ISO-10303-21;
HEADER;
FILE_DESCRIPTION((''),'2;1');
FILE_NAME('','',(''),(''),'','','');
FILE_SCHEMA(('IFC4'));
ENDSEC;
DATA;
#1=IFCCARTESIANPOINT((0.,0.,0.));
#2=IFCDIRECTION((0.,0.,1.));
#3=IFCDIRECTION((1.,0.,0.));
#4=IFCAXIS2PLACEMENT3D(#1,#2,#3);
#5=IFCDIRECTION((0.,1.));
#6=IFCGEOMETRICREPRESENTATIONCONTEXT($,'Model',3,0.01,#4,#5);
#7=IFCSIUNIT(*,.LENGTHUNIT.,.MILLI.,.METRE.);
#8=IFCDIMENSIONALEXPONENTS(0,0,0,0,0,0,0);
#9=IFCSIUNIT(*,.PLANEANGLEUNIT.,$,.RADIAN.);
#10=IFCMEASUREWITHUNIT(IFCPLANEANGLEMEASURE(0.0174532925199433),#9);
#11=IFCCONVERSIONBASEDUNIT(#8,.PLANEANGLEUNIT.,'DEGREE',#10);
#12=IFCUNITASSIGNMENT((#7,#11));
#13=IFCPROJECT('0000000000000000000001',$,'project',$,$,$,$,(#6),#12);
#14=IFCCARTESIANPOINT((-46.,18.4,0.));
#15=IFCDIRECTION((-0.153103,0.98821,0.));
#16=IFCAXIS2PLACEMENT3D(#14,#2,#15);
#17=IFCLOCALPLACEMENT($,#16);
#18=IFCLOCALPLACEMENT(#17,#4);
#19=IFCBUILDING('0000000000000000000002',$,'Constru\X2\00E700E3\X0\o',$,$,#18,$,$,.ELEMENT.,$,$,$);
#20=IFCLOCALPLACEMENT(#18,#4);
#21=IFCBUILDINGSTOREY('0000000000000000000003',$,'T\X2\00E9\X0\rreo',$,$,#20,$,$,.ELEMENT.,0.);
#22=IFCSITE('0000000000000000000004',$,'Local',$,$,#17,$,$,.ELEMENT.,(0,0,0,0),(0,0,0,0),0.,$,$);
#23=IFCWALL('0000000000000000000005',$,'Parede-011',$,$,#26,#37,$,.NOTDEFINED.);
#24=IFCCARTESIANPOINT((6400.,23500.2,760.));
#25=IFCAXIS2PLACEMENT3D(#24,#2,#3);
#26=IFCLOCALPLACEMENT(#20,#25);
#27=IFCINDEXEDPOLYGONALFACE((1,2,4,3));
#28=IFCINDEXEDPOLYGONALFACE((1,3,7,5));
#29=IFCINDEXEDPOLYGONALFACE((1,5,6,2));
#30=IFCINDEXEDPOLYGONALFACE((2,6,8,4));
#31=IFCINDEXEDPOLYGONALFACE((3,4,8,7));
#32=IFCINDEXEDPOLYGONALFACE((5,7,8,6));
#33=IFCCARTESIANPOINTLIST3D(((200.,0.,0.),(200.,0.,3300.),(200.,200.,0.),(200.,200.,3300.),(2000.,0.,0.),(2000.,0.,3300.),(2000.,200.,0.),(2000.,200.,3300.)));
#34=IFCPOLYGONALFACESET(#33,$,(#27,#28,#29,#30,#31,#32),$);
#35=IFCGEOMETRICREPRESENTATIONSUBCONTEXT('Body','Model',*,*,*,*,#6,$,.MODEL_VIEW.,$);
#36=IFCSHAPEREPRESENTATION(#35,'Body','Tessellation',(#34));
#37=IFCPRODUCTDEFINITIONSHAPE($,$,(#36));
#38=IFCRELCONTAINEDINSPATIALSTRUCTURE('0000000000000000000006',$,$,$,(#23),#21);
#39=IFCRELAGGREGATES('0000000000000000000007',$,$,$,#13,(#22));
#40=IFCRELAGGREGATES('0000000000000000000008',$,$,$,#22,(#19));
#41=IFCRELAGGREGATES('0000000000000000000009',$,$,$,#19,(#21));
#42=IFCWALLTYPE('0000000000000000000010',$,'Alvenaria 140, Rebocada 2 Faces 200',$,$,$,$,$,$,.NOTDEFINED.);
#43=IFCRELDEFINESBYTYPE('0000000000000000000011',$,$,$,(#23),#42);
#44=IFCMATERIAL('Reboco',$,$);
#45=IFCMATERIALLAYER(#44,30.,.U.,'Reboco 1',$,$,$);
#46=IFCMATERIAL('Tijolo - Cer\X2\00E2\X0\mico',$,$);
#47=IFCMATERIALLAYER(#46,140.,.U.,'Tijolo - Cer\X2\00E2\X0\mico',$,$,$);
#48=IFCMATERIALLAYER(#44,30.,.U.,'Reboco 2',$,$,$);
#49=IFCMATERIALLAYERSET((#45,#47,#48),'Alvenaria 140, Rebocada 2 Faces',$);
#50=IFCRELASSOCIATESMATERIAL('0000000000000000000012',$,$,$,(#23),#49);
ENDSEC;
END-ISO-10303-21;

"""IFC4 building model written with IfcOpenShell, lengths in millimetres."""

from ifc_helpers import new_model, entity, si_unit, converted_unit, direction, frame, origin_with_axes, place, context, subcontext, project, spatial, line, indexed_curve, outline, extrude, material, layer, layer_set, layer_usage, type_object, element, save


model = new_model("IFC4")

# Units and contexts
model_context = context("Model", 3, precision=0.01, world=origin_with_axes(), true_north=direction((0.0, 1.0)))
body_context = subcontext(model_context, "Body", "Model", "MODEL_VIEW")
ifc_project = project(units=[si_unit("LENGTHUNIT", "METRE", prefix="MILLI"), converted_unit("PLANEANGLEUNIT", "DEGREE", entity("IfcPlaneAngleMeasure", 0.0174532925199433), si_unit("PLANEANGLEUNIT", "RADIAN"), dimensions=[0, 0, 0, 0, 0, 0, 0])], contexts=[model_context])

# Site, building, storey
site_placement = place(None, frame((-46.0, 18.4, 0.0), z_axis=(0.0, 0.0, 1.0), x_axis=(-0.153103, 0.98821, 0.0)))
site = spatial("IfcSite", under=ifc_project, at=site_placement, Name="Local", CompositionType="ELEMENT", RefLatitude=(0, 0, 0, 0), RefLongitude=(0, 0, 0, 0), RefElevation=0.0)
building_placement = place(site_placement, origin_with_axes())
building = spatial("IfcBuilding", under=site, at=building_placement, Name="Construção", CompositionType="ELEMENT")
storey_placement = place(building_placement, origin_with_axes())
storey = spatial("IfcBuildingStorey", under=building, at=storey_placement, Name="Térreo", CompositionType="ELEMENT", Elevation=0.0)

# Wall
ifc_material_1 = material(Name="Reboco")
ifc_layer_1 = layer(ifc_material_1, 30.0, ventilated="UNKNOWN", Name="Reboco 1")
ifc_material_2 = material(Name="Tijolo - Cerâmico")
ifc_layer_2 = layer(ifc_material_2, 140.0, ventilated="UNKNOWN", Name="Tijolo - Cerâmico")
ifc_layer_3 = layer(ifc_material_1, 30.0, ventilated="UNKNOWN", Name="Reboco 2")
ifc_layer_set_1 = layer_set([ifc_layer_1, ifc_layer_2, ifc_layer_3], Name="Alvenaria 140, Rebocada 2 Faces")
ifc_layer_usage_1 = layer_usage(ifc_layer_set_1, "AXIS2", "POSITIVE", 0.0)
wall_type_1 = type_object("IfcWallType", Name="Alvenaria 140, Rebocada 2 Faces 200", PredefinedType="NOTDEFINED")
wall_1_placement = place(storey_placement, frame((6400.0, 23500.2, 760.0), z_axis=(0.0, 0.0, 1.0), x_axis=(1.0, 0.0, 0.0)))
element("IfcWall", 1, at=wall_1_placement, inside=storey, type_object=wall_type_1, material=ifc_layer_usage_1, Name="Parede-011", PredefinedType="NOTDEFINED", context=body_context, shape_type="SweptSolid", body=[
    extrude(outline(indexed_curve([(200.0, 0.0), (2000.0, 0.0), (2000.0, 200.0), (200.0, 200.0)], segments=[line(1, 2, 3, 4, 1)])), origin_with_axes(), (0.0, 0.0, 1.0), 3300.0),
])

save(model, "model.ifc")
